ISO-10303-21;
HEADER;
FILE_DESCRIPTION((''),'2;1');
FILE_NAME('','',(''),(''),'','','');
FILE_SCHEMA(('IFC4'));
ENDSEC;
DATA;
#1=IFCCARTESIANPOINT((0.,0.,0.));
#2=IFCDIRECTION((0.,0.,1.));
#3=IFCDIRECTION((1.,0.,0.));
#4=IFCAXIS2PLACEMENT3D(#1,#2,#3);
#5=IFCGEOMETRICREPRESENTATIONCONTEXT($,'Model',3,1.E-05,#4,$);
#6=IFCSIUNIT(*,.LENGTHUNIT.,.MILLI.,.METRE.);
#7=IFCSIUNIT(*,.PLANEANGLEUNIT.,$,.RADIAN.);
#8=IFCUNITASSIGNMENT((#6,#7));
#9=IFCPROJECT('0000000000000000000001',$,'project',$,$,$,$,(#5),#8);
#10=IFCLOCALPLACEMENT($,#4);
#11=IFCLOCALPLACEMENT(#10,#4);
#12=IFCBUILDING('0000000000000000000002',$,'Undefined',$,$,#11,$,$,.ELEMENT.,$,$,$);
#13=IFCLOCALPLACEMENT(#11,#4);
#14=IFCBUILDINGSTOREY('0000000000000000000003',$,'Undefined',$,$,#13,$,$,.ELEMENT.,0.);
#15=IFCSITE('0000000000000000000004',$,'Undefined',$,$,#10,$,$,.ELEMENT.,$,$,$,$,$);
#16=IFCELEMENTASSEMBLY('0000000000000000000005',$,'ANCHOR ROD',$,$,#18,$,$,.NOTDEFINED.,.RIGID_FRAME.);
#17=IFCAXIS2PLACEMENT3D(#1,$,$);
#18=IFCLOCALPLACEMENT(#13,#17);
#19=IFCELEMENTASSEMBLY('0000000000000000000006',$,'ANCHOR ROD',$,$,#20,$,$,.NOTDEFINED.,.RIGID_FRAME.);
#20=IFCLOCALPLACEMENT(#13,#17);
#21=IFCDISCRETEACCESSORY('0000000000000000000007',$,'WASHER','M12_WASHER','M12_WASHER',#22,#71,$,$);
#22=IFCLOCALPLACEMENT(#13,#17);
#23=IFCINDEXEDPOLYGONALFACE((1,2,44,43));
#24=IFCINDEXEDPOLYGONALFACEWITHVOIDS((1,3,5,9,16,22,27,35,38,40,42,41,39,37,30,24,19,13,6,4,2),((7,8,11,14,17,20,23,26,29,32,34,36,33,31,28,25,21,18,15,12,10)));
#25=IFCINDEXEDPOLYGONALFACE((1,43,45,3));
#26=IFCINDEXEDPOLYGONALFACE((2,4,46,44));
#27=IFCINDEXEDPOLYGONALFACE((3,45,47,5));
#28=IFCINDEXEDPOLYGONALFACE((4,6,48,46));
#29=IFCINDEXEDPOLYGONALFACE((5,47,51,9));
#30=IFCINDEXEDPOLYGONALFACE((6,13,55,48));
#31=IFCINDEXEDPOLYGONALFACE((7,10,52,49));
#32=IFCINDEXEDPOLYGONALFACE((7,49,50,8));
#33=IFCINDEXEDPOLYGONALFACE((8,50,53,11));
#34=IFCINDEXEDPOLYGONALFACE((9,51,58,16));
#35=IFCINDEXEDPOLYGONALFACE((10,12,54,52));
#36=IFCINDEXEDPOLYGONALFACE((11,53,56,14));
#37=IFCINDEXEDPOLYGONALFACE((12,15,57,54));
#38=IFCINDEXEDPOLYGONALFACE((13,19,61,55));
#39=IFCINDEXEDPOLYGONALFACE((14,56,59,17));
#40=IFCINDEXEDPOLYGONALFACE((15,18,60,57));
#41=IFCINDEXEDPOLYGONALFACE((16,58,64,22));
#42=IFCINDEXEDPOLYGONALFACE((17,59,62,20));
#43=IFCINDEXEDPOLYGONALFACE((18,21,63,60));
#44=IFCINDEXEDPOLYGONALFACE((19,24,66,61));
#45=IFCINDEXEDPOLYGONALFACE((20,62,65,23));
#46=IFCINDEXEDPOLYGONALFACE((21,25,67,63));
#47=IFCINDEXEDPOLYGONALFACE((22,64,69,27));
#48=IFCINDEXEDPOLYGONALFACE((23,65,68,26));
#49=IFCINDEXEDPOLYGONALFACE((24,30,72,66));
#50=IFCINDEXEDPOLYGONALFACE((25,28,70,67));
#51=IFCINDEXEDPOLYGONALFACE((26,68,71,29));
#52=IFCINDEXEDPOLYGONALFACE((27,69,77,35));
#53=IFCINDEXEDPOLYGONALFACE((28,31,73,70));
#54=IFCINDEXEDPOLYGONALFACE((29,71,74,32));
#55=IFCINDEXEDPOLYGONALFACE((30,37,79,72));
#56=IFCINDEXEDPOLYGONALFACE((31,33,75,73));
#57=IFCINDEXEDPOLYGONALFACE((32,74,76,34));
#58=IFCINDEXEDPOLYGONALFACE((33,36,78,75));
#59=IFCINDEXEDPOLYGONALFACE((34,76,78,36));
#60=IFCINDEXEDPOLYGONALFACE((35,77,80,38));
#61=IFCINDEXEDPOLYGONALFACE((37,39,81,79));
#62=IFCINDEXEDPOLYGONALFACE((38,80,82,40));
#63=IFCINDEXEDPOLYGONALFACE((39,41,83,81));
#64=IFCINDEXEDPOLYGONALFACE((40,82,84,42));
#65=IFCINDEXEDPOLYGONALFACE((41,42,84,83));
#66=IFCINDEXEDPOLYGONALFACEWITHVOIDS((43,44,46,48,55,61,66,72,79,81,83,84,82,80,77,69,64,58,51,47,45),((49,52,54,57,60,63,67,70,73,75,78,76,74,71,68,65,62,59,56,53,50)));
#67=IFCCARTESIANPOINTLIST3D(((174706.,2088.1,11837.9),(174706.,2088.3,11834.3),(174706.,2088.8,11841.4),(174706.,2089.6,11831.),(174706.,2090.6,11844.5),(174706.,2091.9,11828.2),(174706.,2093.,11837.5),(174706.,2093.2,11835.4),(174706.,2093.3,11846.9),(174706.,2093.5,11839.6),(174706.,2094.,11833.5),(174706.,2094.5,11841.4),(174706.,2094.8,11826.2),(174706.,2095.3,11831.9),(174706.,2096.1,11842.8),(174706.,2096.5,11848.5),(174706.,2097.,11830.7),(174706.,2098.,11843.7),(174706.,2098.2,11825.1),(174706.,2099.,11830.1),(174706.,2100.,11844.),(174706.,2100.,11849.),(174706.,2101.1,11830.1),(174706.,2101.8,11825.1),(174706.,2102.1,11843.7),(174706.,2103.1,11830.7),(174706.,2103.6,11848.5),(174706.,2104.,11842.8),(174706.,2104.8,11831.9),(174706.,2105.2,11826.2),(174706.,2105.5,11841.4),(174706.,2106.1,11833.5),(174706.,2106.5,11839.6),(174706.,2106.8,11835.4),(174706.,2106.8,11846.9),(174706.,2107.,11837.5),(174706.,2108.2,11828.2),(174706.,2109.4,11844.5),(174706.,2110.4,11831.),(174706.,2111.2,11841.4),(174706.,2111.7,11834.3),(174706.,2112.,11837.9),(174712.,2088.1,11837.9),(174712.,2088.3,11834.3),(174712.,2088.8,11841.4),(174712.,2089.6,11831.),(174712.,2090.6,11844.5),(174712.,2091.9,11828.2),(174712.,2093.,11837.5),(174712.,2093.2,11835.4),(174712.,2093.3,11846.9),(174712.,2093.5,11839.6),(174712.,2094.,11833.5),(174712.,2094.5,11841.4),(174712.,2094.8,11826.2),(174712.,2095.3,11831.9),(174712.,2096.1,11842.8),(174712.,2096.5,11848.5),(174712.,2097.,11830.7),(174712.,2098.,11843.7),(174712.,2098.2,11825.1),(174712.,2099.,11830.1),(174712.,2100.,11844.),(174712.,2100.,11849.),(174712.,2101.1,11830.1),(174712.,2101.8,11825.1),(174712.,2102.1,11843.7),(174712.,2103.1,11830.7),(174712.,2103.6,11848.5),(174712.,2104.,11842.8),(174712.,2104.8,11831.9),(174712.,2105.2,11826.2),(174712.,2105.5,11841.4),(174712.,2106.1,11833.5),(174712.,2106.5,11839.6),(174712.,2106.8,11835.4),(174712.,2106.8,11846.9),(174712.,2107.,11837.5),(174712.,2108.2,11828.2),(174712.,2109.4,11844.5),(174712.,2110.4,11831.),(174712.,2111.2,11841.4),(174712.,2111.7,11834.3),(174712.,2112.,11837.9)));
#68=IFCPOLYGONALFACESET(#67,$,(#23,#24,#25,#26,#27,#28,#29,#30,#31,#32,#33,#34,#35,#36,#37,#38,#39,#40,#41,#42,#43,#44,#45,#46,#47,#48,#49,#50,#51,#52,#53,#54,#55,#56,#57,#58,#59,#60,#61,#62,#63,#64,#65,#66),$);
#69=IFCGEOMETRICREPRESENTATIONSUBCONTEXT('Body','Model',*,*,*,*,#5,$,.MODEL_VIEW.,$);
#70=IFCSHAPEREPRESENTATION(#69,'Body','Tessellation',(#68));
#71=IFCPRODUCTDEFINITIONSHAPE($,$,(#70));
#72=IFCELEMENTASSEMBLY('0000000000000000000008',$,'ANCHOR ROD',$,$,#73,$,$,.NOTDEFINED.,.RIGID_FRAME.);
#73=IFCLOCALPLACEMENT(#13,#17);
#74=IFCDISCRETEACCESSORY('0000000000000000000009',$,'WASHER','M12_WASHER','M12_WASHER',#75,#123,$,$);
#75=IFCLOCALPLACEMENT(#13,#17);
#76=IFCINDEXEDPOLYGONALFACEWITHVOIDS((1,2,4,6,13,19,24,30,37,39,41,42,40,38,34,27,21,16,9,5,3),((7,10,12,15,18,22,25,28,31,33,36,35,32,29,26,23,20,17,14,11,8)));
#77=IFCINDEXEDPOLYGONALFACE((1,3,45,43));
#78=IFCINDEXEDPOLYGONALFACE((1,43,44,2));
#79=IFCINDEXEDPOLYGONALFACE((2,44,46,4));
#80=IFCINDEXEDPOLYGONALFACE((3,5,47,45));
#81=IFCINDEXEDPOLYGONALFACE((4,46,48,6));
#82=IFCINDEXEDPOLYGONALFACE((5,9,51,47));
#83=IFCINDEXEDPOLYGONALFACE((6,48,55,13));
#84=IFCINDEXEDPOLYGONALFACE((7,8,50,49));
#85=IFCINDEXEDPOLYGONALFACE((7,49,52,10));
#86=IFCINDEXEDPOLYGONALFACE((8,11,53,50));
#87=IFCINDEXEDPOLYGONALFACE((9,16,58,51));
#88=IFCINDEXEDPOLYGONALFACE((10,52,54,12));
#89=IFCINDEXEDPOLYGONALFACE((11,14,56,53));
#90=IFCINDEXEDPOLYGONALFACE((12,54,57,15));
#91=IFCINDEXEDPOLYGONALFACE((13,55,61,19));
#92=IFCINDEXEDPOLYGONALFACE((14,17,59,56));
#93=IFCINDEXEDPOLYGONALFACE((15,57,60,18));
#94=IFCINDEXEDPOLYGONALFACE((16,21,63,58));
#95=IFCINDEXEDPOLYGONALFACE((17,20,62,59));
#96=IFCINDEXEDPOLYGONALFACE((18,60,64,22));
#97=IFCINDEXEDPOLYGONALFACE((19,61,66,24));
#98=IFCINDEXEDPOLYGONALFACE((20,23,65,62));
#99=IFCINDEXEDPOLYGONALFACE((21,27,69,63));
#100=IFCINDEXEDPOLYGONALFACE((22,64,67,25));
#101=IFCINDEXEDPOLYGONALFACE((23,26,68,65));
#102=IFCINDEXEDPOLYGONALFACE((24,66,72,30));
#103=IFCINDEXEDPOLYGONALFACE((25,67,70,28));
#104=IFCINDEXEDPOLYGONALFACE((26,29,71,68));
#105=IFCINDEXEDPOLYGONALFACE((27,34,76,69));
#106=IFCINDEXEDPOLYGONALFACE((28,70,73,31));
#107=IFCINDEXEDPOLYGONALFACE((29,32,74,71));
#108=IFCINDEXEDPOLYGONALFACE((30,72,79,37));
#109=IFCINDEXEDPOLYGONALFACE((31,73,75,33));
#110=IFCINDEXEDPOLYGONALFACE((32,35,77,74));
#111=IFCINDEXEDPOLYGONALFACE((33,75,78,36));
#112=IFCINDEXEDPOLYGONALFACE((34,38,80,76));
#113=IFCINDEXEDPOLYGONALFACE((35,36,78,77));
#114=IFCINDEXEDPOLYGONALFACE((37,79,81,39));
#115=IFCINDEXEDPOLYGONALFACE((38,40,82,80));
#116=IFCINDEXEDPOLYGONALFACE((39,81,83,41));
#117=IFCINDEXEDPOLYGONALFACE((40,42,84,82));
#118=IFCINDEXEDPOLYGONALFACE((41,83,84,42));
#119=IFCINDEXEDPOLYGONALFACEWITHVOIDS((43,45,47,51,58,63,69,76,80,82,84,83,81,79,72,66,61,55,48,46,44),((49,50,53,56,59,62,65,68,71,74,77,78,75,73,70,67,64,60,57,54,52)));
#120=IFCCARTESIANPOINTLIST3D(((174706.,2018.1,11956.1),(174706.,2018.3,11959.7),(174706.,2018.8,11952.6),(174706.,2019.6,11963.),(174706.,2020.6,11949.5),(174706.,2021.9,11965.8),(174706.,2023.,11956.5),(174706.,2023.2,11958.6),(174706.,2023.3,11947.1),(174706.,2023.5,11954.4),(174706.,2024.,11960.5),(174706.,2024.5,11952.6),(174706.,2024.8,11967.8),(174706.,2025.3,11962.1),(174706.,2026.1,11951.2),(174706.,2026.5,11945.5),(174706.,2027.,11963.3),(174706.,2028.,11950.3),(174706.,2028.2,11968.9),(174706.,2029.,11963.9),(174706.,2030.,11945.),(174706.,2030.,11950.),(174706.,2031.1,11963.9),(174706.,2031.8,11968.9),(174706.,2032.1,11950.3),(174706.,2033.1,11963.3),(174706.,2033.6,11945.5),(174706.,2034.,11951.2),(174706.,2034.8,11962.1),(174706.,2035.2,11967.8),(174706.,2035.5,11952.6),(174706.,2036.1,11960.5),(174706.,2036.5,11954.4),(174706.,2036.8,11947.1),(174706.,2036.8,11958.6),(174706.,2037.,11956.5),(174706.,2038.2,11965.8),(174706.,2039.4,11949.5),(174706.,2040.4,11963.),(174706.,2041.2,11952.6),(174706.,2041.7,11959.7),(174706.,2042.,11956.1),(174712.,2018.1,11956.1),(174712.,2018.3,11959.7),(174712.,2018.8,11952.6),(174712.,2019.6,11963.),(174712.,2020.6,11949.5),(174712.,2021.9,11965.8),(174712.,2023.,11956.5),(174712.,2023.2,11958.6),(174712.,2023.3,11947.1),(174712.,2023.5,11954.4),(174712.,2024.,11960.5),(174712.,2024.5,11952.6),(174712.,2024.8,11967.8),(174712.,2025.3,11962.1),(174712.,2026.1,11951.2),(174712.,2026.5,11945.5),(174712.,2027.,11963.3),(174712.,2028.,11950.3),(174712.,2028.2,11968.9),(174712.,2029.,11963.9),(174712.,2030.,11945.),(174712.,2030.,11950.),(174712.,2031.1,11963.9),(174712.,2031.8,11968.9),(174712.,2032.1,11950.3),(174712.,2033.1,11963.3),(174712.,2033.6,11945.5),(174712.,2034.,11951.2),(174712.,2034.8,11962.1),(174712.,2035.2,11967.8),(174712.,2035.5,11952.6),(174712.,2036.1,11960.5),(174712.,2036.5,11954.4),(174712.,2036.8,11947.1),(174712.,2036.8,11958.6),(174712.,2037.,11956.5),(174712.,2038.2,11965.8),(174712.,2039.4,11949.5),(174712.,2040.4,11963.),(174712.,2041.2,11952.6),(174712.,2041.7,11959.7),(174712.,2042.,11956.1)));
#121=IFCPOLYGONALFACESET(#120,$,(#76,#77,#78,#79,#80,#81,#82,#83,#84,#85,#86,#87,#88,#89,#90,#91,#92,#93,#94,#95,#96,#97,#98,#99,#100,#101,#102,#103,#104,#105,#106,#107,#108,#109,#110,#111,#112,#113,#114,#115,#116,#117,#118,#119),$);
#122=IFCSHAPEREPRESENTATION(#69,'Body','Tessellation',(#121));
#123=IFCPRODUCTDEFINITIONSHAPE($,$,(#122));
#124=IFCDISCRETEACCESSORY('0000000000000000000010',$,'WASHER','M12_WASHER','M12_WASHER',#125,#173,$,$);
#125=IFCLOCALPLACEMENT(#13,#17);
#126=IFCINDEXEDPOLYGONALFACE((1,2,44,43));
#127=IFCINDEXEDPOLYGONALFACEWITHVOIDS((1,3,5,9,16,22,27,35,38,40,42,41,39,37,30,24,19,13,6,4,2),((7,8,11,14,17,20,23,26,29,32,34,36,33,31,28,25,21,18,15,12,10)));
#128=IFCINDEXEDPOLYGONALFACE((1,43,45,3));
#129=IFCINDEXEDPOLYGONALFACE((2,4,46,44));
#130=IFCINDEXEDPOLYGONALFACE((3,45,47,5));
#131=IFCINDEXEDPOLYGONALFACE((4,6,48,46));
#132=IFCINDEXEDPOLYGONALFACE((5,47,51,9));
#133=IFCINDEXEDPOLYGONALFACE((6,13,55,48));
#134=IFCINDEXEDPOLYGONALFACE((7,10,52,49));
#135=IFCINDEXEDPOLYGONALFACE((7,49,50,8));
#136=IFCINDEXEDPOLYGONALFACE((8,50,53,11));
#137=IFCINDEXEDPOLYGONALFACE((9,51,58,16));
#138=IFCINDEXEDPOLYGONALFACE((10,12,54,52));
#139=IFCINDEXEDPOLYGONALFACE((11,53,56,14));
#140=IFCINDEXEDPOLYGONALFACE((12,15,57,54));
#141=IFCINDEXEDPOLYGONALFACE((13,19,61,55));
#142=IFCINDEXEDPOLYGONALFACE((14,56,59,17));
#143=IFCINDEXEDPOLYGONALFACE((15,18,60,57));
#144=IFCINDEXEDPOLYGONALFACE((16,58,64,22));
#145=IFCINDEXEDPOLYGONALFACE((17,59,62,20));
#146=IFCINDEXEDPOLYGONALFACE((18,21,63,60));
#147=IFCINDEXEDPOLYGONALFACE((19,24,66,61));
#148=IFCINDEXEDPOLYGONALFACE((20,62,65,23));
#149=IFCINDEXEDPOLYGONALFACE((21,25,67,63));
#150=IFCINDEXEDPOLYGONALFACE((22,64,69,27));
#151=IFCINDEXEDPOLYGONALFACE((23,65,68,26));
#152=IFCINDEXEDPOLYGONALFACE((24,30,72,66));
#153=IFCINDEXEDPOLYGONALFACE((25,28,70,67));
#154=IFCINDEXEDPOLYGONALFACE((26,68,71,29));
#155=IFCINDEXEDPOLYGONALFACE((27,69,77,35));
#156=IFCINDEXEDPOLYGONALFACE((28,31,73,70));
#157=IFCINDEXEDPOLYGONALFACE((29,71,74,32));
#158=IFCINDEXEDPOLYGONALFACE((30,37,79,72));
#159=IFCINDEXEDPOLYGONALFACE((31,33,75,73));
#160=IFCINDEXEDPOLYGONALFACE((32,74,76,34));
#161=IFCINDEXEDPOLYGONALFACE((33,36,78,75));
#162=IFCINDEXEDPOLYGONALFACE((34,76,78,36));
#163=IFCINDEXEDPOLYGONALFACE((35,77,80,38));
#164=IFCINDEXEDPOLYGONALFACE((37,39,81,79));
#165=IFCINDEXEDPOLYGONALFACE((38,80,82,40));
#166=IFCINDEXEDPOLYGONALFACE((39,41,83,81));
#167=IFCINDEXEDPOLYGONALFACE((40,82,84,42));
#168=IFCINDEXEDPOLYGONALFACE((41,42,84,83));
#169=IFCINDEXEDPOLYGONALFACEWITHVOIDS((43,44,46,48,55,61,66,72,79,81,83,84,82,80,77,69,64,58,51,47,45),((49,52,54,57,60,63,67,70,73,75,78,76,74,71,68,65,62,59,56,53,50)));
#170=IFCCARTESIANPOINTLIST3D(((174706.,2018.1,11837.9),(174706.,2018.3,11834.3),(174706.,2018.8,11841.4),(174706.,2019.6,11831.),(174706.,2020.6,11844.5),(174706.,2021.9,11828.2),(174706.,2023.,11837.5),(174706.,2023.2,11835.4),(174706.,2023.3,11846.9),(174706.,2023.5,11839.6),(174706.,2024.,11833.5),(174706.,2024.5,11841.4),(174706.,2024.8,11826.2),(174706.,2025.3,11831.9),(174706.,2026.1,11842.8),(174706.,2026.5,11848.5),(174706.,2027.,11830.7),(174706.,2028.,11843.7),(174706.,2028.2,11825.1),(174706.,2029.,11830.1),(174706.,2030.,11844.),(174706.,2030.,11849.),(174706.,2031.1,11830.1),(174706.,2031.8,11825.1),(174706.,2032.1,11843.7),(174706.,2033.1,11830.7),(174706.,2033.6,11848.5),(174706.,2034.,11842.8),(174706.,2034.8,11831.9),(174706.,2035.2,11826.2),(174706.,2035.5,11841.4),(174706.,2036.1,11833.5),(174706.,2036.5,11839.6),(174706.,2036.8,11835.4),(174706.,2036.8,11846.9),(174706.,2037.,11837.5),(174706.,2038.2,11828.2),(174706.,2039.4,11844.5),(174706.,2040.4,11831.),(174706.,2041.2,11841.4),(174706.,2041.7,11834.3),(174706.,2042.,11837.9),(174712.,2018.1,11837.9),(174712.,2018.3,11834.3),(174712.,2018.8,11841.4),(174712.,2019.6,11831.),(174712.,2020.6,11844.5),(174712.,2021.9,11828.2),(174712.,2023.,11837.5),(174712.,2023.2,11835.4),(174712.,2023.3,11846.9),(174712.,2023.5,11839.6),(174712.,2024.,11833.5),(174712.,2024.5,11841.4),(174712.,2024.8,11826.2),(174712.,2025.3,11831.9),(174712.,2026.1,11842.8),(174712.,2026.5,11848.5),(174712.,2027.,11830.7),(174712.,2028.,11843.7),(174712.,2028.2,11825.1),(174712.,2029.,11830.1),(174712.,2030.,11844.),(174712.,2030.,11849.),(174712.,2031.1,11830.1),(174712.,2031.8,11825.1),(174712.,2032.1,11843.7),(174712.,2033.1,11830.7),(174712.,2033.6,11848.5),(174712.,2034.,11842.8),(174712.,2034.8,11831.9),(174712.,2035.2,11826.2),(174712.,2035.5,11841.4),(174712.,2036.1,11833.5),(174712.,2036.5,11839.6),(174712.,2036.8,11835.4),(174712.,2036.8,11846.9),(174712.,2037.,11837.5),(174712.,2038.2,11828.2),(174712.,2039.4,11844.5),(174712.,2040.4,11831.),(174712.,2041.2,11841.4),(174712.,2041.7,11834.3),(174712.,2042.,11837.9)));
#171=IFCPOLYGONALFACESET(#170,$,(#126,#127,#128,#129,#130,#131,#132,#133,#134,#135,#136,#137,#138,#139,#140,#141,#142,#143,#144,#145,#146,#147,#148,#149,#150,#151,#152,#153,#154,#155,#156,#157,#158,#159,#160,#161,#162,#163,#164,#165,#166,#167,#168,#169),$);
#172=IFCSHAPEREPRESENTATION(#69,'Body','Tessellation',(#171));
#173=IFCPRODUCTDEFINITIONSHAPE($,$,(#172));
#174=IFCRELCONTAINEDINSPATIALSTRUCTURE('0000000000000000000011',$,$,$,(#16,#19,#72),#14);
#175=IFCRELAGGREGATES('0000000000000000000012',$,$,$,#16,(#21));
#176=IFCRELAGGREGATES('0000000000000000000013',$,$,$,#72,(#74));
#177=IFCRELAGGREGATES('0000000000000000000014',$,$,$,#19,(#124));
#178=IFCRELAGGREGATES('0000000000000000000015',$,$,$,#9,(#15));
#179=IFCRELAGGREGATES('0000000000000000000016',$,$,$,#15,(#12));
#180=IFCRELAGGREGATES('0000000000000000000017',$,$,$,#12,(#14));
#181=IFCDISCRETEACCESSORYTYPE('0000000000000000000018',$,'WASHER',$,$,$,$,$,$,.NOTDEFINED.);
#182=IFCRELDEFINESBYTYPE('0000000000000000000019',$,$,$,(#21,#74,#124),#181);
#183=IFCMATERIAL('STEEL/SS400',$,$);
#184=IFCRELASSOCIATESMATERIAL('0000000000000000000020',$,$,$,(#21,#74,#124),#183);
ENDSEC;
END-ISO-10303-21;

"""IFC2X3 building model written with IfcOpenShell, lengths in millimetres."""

from ifc_helpers import new_model, si_unit, frame, origin_with_axes, origin_2d_with_axis, place, context, subcontext, project, spatial, hollow_circle, extrude, material, type_object, element, aggregate, save


model = new_model("IFC2X3")

# Units and contexts
model_context = context("Model", 3, precision=1e-05, world=origin_with_axes())
body_context = subcontext(model_context, "Body", "Model", "MODEL_VIEW")
ifc_project = project(units=[si_unit("LENGTHUNIT", "METRE", prefix="MILLI"), si_unit("PLANEANGLEUNIT", "RADIAN")], contexts=[model_context])

# Site, building, storey
site_placement = place(None, origin_with_axes())
site = spatial("IfcSite", under=ifc_project, at=site_placement, Name="Undefined", CompositionType="ELEMENT")
building_placement = place(site_placement, origin_with_axes())
building = spatial("IfcBuilding", under=site, at=building_placement, Name="Undefined", CompositionType="ELEMENT")
storey_placement = place(building_placement, origin_with_axes())
storey = spatial("IfcBuildingStorey", under=building, at=storey_placement, Name="Undefined", CompositionType="ELEMENT", Elevation=0.0)

# Shared definitions
ifc_material_1 = material(Name="STEEL/SS400")

# Element assemblies
assembly_1_placement = place(storey_placement, origin_with_axes())
assembly_1 = element("IfcElementAssembly", 1, at=assembly_1_placement, inside=storey, Name="ANCHOR ROD", AssemblyPlace="NOTDEFINED", PredefinedType="RIGID_FRAME")
assembly_2_placement = place(storey_placement, origin_with_axes())
assembly_2 = element("IfcElementAssembly", 2, at=assembly_2_placement, inside=storey, Name="ANCHOR ROD", AssemblyPlace="NOTDEFINED", PredefinedType="RIGID_FRAME")
discrete_accessory_type_1 = type_object("IfcDiscreteAccessoryType", Name="WASHER")

# Discrete accessory
discrete_accessory_1_placement = place(assembly_1_placement, frame((174712.0, 2100.0, 11837.0), z_axis=(0.0, -1.0, 0.0), x_axis=(-1.0, 0.0, 0.0)))
discrete_accessory_1 = element("IfcDiscreteAccessory", 3, at=discrete_accessory_1_placement, type_object=discrete_accessory_type_1, material=ifc_material_1, Name="WASHER", Description="M12_WASHER", ObjectType="M12_WASHER", context=body_context, shape_type="SweptSolid", body=[
    extrude(hollow_circle(Radius=12.0, WallThickness=5.0, at=origin_2d_with_axis()), frame((6.0, 0.0, 0.0), z_axis=(-1.0, 0.0, 0.0), x_axis=(0.0, -1.0, 0.0)), (0.0, 0.0, 1.0), 6.0),
])
aggregate(assembly_1, [discrete_accessory_1])

# Element assembly, discrete accessory
assembly_3_placement = place(storey_placement, origin_with_axes())
assembly_3 = element("IfcElementAssembly", 4, at=assembly_3_placement, inside=storey, Name="ANCHOR ROD", AssemblyPlace="NOTDEFINED", PredefinedType="RIGID_FRAME")
discrete_accessory_2_placement = place(assembly_3_placement, frame((174712.0, 2030.0, 11957.0), z_axis=(0.0, 1.0, 0.0), x_axis=(-1.0, 0.0, 0.0)))
discrete_accessory_2 = element("IfcDiscreteAccessory", 5, at=discrete_accessory_2_placement, type_object=discrete_accessory_type_1, material=ifc_material_1, Name="WASHER", Description="M12_WASHER", ObjectType="M12_WASHER", context=body_context, shape_type="SweptSolid", body=[
    extrude(hollow_circle(Radius=12.0, WallThickness=5.0, at=origin_2d_with_axis()), frame((6.0, 0.0, 0.0), z_axis=(-1.0, 0.0, 0.0), x_axis=(0.0, -1.0, 0.0)), (0.0, 0.0, 1.0), 6.0),
])
aggregate(assembly_3, [discrete_accessory_2])

# Discrete accessory
discrete_accessory_3_placement = place(assembly_2_placement, frame((174712.0, 2030.0, 11837.0), z_axis=(0.0, -1.0, 0.0), x_axis=(-1.0, 0.0, 0.0)))
discrete_accessory_3 = element("IfcDiscreteAccessory", 6, at=discrete_accessory_3_placement, type_object=discrete_accessory_type_1, material=ifc_material_1, Name="WASHER", Description="M12_WASHER", ObjectType="M12_WASHER", context=body_context, shape_type="SweptSolid", body=[
    extrude(hollow_circle(Radius=12.0, WallThickness=5.0, at=origin_2d_with_axis()), frame((6.0, 0.0, 0.0), z_axis=(-1.0, 0.0, 0.0), x_axis=(0.0, -1.0, 0.0)), (0.0, 0.0, 1.0), 6.0),
])
aggregate(assembly_2, [discrete_accessory_3])

save(model, "model.ifc")
